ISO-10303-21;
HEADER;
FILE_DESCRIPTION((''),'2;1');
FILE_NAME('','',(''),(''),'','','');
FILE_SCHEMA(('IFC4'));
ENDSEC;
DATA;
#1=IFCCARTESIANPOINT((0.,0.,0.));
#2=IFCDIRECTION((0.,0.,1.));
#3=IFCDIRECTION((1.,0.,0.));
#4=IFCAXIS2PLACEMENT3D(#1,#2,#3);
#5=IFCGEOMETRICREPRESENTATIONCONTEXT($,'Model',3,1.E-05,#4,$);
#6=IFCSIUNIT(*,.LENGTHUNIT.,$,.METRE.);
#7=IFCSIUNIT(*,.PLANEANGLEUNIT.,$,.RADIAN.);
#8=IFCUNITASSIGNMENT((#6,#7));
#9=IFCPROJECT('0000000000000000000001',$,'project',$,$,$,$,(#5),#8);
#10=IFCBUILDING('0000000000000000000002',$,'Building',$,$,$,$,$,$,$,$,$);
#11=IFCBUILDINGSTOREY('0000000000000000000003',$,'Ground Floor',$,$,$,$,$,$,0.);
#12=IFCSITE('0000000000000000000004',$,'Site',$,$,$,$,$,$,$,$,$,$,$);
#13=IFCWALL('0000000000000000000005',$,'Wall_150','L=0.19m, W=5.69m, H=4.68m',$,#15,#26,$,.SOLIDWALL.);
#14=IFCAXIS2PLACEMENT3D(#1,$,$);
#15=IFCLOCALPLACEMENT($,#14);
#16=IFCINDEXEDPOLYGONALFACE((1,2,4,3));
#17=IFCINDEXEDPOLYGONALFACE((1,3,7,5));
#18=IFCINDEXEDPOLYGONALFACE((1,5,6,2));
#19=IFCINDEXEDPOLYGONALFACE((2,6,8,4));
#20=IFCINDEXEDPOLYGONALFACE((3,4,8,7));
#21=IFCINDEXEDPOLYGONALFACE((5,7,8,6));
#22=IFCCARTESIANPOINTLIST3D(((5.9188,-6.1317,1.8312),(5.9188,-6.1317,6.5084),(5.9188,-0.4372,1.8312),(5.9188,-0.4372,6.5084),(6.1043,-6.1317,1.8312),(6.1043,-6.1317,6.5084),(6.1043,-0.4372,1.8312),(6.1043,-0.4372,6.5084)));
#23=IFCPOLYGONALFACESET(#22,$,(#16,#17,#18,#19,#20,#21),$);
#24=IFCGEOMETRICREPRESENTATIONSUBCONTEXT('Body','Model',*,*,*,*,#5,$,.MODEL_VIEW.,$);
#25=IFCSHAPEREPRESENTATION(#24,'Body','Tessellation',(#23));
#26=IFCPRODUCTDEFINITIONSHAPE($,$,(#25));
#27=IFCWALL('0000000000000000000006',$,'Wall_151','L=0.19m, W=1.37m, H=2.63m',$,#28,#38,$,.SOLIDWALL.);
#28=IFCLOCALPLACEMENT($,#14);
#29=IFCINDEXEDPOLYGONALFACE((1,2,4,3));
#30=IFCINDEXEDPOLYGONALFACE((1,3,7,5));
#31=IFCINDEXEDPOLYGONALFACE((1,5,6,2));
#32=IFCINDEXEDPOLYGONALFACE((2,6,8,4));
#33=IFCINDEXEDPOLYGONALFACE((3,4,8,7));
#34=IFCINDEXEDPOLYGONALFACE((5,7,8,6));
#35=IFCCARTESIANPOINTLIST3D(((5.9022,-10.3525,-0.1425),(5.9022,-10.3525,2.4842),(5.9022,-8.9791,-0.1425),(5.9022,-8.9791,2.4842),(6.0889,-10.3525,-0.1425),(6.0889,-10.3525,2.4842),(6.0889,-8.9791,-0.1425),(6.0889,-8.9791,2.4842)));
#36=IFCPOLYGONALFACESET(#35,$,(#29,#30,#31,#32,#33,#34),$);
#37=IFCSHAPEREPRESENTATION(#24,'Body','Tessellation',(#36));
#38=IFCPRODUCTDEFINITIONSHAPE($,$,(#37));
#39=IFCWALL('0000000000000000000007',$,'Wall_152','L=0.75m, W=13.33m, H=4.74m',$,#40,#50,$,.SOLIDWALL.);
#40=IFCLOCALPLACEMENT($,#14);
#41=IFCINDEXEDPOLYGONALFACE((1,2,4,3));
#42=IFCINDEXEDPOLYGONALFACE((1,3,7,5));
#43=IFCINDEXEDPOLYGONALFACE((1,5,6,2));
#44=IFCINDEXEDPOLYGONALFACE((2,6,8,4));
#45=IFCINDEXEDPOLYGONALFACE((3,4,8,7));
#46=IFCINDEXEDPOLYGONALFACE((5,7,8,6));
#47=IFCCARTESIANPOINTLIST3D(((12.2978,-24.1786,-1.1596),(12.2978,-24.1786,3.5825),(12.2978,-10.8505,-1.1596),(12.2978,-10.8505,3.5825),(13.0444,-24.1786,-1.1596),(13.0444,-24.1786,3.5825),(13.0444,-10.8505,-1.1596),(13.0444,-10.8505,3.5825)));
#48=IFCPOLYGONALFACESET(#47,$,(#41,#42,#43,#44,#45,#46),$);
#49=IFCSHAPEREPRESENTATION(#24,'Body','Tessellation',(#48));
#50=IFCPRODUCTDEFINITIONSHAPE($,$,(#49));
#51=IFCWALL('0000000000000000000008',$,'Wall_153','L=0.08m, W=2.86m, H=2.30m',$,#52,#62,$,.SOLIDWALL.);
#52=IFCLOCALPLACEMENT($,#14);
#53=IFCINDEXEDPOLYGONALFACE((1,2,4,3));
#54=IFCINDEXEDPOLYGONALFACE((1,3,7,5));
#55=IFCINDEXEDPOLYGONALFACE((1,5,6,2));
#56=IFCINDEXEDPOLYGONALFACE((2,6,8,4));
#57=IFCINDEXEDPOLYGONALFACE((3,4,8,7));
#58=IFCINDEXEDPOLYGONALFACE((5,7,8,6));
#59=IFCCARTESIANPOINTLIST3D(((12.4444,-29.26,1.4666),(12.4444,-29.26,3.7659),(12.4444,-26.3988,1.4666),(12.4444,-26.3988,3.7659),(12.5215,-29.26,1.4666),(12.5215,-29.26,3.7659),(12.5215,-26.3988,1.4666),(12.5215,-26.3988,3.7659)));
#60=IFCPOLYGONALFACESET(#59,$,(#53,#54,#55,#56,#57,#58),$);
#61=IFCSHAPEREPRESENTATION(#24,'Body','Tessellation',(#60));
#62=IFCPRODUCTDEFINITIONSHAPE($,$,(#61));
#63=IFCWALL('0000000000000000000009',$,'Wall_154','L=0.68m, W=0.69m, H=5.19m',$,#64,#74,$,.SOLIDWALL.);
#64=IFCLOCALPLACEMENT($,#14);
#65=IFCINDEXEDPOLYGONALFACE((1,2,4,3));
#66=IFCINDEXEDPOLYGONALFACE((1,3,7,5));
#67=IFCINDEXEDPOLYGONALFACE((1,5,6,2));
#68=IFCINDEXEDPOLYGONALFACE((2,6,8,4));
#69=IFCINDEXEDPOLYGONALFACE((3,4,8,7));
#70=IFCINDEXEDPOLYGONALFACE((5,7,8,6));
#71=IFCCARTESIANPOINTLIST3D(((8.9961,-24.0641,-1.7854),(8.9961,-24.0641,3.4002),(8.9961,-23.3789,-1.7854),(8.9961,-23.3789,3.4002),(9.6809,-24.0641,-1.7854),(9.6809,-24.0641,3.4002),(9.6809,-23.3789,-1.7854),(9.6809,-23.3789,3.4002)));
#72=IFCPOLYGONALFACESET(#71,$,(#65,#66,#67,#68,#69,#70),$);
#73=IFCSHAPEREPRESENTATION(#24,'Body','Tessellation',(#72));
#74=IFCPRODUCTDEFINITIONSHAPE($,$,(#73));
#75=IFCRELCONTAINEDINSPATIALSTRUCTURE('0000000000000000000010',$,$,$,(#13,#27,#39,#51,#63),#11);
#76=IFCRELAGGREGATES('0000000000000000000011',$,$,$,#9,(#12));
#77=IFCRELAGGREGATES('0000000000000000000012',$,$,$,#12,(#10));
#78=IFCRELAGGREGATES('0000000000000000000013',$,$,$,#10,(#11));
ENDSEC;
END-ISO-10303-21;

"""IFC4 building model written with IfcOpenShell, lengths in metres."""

from ifc_helpers import new_model, si_unit, frame, origin_with_axes, origin_2d, context, subcontext, project, spatial, rectangle, extrude, element, save


model = new_model("IFC4")

# Units and contexts
model_context = context("Model", 3, precision=1e-05, world=origin_with_axes())
body_context = subcontext(model_context, "Body", "Model", "MODEL_VIEW")
ifc_project = project(units=[si_unit("LENGTHUNIT", "METRE"), si_unit("PLANEANGLEUNIT", "RADIAN")], contexts=[model_context])

# Site, building, storey
site = spatial("IfcSite", under=ifc_project, Name="Site")
building = spatial("IfcBuilding", under=site, Name="Building")
storey = spatial("IfcBuildingStorey", under=building, Name="Ground Floor", Elevation=0.0)

# Walls
element("IfcWall", 1, inside=storey, Name="Wall_150", Description="L=0.19m, W=5.69m, H=4.68m", PredefinedType="SOLIDWALL", context=body_context, shape_type="SweptSolid", body=[
    extrude(rectangle(XDim=0.1855, YDim=5.6945, at=origin_2d()), frame((6.0116, -3.2845, 1.8312), z_axis=(0.0, 0.0, 1.0), x_axis=(1.0, 0.0, 0.0)), (0.0, 0.0, 1.0), 4.6772),
])
element("IfcWall", 2, inside=storey, Name="Wall_151", Description="L=0.19m, W=1.37m, H=2.63m", PredefinedType="SOLIDWALL", context=body_context, shape_type="SweptSolid", body=[
    extrude(rectangle(XDim=0.1867, YDim=1.3734, at=origin_2d()), frame((5.9956, -9.6658, -0.1425), z_axis=(0.0, 0.0, 1.0), x_axis=(1.0, 0.0, 0.0)), (0.0, 0.0, 1.0), 2.6267),
])
element("IfcWall", 3, inside=storey, Name="Wall_152", Description="L=0.75m, W=13.33m, H=4.74m", PredefinedType="SOLIDWALL", context=body_context, shape_type="SweptSolid", body=[
    extrude(rectangle(XDim=0.7465, YDim=13.3281, at=origin_2d()), frame((12.6711, -17.5145, -1.1596), z_axis=(0.0, 0.0, 1.0), x_axis=(1.0, 0.0, 0.0)), (0.0, 0.0, 1.0), 4.7421),
])
element("IfcWall", 4, inside=storey, Name="Wall_153", Description="L=0.08m, W=2.86m, H=2.30m", PredefinedType="SOLIDWALL", context=body_context, shape_type="SweptSolid", body=[
    extrude(rectangle(XDim=0.0771, YDim=2.8612, at=origin_2d()), frame((12.4829, -27.8294, 1.4666), z_axis=(0.0, 0.0, 1.0), x_axis=(1.0, 0.0, 0.0)), (0.0, 0.0, 1.0), 2.2993),
])
element("IfcWall", 5, inside=storey, Name="Wall_154", Description="L=0.68m, W=0.69m, H=5.19m", PredefinedType="SOLIDWALL", context=body_context, shape_type="SweptSolid", body=[
    extrude(rectangle(XDim=0.6848, YDim=0.6852, at=origin_2d()), frame((9.3385, -23.7215, -1.7854), z_axis=(0.0, 0.0, 1.0), x_axis=(1.0, 0.0, 0.0)), (0.0, 0.0, 1.0), 5.1856),
])

save(model, "model.ifc")
